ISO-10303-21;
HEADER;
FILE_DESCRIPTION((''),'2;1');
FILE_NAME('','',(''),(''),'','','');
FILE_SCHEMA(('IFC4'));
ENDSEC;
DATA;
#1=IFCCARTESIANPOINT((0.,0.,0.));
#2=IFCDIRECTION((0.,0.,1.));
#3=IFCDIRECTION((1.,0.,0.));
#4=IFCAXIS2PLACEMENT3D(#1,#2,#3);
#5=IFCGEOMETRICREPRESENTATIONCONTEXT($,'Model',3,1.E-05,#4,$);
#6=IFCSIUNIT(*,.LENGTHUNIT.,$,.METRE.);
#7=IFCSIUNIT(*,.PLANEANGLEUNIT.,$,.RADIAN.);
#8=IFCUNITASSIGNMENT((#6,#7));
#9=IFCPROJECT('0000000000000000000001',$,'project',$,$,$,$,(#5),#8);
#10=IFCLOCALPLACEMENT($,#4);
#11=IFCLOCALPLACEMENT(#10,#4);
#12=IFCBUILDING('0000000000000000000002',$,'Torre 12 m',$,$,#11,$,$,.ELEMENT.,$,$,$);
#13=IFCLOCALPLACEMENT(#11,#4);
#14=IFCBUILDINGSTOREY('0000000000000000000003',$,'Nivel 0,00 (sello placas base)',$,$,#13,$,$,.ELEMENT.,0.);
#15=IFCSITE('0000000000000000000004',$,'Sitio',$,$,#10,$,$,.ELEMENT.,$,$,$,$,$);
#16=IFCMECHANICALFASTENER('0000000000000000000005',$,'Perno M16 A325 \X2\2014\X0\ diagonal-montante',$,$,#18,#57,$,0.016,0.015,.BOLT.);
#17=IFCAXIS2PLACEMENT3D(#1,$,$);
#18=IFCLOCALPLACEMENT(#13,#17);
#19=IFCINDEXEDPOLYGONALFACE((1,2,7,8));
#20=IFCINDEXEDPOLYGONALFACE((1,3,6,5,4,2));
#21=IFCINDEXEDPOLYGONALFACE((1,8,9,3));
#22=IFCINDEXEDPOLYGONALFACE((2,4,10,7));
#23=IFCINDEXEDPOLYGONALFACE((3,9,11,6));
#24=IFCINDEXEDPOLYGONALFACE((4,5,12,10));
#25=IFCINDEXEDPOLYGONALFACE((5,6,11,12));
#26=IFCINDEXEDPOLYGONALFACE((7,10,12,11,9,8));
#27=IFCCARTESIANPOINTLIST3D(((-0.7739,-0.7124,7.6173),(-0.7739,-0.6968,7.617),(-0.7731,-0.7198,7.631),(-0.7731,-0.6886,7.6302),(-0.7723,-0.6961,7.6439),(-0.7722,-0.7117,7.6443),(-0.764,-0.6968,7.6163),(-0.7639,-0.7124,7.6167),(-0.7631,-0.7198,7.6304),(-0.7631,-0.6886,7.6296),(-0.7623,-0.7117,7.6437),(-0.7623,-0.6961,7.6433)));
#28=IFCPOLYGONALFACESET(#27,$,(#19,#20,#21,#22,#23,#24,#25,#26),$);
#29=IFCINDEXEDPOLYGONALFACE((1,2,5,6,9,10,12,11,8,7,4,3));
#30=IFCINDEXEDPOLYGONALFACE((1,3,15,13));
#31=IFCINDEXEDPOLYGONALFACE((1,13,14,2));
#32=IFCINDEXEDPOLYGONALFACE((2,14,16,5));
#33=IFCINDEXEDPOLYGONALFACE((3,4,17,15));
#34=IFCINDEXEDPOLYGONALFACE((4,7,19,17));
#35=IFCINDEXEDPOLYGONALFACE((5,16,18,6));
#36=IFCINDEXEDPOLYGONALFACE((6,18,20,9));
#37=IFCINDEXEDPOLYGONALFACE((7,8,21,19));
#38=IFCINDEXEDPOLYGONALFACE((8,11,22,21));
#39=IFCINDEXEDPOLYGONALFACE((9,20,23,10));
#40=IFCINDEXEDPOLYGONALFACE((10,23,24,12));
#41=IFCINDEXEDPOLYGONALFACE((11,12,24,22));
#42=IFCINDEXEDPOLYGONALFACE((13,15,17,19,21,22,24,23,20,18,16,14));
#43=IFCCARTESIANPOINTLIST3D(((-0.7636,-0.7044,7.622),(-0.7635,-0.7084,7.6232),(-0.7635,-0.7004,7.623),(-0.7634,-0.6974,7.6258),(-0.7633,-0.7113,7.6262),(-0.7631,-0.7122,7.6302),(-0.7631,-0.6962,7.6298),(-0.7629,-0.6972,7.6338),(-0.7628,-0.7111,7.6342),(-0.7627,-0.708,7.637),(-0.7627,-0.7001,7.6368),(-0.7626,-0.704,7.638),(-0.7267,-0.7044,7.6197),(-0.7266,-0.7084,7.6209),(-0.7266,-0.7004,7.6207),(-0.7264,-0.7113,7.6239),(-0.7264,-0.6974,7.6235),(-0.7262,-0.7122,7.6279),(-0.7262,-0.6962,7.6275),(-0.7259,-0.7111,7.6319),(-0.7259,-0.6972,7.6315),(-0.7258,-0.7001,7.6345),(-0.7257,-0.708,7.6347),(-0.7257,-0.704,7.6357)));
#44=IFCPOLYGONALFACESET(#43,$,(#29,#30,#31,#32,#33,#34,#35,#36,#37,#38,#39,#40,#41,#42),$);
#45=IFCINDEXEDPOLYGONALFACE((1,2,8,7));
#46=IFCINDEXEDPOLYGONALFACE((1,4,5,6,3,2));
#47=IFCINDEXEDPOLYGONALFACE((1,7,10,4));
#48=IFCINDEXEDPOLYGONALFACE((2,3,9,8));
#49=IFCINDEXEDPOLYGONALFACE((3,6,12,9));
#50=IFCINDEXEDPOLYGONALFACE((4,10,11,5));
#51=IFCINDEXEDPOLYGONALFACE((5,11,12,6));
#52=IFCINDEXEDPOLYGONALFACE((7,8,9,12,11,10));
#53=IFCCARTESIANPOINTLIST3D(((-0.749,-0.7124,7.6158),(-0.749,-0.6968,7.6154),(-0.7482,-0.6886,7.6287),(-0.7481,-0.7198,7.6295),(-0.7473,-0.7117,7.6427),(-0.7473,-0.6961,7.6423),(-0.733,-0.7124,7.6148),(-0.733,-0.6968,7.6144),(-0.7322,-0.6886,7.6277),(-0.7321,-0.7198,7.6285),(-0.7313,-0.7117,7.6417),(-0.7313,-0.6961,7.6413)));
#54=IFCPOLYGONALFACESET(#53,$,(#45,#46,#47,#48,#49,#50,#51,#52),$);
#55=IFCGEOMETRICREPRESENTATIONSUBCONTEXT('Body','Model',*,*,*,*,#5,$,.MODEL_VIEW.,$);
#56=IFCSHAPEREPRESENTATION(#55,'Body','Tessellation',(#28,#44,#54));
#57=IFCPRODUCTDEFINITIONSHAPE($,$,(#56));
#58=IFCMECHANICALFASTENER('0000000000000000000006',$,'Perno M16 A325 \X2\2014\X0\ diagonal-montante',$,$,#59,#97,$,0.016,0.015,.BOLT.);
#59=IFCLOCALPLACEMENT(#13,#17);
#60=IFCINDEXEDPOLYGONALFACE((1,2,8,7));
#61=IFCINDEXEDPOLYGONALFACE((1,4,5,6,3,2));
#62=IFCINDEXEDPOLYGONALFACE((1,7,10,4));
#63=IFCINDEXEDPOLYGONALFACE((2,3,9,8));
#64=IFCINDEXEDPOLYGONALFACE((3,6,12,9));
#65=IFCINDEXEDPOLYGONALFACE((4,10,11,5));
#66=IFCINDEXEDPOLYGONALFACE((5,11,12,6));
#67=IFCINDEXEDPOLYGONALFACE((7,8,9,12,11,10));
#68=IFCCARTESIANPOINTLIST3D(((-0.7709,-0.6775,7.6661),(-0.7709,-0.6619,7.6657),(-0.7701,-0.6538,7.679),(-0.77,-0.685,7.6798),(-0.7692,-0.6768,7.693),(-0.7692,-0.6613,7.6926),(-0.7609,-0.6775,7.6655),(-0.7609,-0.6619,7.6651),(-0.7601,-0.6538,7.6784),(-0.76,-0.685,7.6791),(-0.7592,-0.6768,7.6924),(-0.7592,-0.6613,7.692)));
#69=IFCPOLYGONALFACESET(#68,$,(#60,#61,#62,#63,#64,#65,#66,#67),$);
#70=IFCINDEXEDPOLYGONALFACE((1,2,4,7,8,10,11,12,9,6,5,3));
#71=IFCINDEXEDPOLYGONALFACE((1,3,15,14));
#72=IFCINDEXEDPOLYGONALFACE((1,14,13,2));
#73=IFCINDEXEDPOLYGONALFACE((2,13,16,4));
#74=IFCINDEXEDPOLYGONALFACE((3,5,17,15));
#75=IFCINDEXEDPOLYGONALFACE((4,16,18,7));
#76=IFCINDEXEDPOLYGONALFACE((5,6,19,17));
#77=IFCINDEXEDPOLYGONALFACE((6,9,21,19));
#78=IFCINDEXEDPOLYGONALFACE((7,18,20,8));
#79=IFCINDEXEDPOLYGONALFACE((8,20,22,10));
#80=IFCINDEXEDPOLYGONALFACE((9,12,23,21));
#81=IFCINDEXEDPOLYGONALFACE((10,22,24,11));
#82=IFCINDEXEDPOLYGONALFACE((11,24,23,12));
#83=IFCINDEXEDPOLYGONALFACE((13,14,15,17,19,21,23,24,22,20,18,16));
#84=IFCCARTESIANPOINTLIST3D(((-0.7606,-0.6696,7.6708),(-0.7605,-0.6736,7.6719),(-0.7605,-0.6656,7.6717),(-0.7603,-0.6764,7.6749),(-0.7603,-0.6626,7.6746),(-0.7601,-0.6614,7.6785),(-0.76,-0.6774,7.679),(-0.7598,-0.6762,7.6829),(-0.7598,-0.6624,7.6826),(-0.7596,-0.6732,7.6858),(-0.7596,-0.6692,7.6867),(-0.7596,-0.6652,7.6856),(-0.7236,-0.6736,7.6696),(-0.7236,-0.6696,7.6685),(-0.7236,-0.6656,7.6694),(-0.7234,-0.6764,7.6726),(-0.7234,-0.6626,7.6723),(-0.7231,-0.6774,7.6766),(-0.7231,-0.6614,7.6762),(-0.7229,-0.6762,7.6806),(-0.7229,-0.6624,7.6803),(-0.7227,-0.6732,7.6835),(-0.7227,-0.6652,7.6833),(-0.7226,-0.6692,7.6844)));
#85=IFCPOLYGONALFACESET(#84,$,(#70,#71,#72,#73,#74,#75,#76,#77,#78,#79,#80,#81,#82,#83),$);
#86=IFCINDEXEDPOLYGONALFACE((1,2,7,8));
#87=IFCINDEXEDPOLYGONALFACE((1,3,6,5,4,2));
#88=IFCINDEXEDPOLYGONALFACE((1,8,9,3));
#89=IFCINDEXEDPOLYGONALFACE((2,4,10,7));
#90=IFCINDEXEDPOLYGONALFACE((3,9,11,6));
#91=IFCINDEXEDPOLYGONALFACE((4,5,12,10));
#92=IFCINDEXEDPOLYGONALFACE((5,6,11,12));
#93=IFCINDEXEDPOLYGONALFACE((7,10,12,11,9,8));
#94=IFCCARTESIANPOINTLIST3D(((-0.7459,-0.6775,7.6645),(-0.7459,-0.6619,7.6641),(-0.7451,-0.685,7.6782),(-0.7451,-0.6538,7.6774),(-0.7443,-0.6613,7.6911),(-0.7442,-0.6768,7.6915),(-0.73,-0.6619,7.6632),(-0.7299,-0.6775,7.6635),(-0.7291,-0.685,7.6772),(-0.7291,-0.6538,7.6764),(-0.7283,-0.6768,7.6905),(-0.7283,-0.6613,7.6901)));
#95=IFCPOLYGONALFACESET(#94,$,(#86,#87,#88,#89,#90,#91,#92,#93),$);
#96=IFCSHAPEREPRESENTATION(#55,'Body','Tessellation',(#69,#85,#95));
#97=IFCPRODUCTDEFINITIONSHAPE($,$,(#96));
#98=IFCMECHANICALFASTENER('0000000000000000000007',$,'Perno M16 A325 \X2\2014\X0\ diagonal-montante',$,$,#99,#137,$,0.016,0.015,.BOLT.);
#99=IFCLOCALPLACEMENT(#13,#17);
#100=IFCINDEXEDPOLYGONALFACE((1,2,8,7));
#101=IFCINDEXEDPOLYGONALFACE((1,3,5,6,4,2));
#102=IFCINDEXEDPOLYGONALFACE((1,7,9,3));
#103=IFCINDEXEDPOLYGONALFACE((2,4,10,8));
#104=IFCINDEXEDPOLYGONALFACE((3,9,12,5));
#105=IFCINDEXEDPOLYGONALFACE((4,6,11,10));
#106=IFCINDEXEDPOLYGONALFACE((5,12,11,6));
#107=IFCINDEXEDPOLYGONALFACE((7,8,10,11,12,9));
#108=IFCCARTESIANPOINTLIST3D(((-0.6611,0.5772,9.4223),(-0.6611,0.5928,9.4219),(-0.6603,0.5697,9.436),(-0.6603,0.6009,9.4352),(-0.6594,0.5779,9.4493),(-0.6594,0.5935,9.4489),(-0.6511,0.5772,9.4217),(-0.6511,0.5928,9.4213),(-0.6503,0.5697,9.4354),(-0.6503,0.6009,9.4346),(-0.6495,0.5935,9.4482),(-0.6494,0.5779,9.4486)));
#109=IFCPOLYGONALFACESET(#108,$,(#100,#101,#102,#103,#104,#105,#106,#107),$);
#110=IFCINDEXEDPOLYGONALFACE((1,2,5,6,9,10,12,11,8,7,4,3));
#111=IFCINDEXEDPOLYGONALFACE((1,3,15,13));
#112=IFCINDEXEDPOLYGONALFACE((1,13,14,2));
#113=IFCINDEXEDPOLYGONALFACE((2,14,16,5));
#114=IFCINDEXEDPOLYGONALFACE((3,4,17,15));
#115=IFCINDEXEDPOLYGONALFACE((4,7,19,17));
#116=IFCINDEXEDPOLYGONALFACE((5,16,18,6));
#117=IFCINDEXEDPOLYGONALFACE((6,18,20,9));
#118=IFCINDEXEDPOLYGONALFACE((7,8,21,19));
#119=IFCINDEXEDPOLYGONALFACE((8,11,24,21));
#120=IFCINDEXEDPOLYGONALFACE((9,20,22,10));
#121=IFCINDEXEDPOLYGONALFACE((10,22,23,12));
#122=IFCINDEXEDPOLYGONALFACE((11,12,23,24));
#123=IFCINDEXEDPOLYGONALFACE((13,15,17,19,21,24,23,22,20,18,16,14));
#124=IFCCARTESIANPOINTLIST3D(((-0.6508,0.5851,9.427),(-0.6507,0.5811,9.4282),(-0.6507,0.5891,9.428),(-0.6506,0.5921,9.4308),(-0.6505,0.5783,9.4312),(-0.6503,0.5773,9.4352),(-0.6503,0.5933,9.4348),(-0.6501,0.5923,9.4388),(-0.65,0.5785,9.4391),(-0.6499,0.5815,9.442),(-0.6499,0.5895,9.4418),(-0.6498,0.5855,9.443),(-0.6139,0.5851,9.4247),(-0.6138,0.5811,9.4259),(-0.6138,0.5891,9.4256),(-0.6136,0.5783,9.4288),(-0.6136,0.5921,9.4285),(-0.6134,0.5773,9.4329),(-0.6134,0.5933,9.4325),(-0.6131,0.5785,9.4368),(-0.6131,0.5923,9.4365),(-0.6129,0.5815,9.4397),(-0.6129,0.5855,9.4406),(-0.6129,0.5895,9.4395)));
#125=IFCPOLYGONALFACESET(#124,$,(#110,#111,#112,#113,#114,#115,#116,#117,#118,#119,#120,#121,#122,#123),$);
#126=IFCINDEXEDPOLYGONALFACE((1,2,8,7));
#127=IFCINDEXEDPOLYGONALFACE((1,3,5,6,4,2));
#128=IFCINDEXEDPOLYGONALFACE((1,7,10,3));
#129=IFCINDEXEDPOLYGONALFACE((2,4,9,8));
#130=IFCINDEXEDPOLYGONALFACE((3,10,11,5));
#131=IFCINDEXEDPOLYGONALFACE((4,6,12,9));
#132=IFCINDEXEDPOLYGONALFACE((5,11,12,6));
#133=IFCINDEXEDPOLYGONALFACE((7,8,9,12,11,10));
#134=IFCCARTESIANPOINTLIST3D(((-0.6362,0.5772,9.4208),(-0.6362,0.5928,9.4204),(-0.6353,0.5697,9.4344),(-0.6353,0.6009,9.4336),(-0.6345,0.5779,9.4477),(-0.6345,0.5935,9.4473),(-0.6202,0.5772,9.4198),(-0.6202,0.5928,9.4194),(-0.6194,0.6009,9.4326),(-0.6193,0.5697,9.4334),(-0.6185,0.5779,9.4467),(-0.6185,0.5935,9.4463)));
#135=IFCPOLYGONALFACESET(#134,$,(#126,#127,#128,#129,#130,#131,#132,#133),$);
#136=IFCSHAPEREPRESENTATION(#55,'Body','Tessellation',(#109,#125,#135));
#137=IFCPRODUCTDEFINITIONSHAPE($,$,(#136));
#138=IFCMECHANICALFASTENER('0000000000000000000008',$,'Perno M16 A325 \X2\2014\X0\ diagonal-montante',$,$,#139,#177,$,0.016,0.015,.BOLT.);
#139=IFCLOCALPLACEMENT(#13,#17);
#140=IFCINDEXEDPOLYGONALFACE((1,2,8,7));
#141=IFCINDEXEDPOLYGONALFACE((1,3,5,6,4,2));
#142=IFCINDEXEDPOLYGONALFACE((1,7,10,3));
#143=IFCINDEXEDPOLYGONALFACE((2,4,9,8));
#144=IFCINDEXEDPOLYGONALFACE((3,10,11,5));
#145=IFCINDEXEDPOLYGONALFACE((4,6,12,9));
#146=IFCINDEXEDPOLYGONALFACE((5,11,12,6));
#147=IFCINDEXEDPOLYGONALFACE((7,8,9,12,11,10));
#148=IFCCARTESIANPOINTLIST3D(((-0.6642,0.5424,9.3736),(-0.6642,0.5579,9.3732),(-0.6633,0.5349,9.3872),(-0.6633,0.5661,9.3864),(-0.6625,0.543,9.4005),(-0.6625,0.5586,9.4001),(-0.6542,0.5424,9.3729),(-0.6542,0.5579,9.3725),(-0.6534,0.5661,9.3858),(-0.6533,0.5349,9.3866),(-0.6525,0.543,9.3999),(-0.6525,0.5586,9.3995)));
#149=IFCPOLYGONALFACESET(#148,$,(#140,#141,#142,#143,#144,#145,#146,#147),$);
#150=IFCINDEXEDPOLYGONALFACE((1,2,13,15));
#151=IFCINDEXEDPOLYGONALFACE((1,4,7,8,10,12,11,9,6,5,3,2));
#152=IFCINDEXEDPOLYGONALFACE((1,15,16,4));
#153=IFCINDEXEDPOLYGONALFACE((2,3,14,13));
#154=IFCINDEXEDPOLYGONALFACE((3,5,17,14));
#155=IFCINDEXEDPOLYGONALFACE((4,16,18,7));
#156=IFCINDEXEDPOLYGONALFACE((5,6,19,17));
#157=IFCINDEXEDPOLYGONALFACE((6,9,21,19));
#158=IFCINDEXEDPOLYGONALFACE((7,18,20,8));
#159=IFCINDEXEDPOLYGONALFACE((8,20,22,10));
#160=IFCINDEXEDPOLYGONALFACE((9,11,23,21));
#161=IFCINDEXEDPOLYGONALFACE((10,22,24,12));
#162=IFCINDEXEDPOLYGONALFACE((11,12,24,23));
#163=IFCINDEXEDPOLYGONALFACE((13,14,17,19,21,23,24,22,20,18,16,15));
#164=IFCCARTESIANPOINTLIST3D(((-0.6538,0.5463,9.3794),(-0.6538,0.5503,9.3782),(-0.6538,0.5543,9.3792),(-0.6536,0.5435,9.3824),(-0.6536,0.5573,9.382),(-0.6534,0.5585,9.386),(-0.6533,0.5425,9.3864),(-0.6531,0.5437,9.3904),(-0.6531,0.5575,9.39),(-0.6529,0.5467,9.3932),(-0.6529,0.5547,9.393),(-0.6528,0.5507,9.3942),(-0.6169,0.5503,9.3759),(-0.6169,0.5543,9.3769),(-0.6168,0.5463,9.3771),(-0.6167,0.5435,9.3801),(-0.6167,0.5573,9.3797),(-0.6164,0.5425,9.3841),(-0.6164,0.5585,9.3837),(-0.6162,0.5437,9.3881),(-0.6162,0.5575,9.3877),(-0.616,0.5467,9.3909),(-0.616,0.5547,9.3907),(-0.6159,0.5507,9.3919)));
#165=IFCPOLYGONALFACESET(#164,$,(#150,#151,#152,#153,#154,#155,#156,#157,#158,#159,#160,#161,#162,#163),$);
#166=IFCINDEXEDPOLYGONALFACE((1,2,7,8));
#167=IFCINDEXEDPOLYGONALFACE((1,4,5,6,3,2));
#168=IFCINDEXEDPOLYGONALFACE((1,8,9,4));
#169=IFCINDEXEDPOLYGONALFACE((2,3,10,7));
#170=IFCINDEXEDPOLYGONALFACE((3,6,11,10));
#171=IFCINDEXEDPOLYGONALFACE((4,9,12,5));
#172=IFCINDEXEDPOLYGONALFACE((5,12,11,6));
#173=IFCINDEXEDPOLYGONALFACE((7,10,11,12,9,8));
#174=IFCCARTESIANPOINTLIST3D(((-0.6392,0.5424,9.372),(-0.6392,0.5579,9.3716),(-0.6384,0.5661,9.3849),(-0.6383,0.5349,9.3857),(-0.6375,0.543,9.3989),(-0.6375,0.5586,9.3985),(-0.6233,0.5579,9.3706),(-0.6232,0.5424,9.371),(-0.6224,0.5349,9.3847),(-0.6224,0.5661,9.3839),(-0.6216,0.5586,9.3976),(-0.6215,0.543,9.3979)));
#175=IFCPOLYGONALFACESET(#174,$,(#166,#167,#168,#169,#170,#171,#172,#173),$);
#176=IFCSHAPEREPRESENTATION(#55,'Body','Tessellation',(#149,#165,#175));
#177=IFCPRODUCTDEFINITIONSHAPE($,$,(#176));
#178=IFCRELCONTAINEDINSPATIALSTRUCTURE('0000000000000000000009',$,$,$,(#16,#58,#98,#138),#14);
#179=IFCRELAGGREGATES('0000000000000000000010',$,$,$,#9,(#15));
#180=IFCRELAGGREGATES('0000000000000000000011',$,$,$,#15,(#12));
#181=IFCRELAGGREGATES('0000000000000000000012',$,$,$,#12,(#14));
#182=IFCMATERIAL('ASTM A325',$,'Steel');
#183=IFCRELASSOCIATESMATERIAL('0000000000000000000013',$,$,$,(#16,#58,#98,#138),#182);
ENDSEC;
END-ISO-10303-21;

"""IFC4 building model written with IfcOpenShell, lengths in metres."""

from ifc_helpers import new_model, si_unit, frame, origin_with_axes, place, context, subcontext, project, spatial, polyline, outline, extrude, material, element, save


model = new_model("IFC4")

# Units and contexts
model_context = context("Model", 3, precision=1e-05, world=origin_with_axes())
body_context = subcontext(model_context, "Body", "Model", "MODEL_VIEW")
ifc_project = project(units=[si_unit("LENGTHUNIT", "METRE"), si_unit("PLANEANGLEUNIT", "RADIAN")], contexts=[model_context])

# Site, building, storey
site_placement = place(None, origin_with_axes())
site = spatial("IfcSite", under=ifc_project, at=site_placement, Name="Sitio", CompositionType="ELEMENT")
building_placement = place(site_placement, origin_with_axes())
building = spatial("IfcBuilding", under=site, at=building_placement, Name="Torre 12 m", CompositionType="ELEMENT")
storey_placement = place(building_placement, origin_with_axes())
storey = spatial("IfcBuildingStorey", under=building, at=storey_placement, Name="Nivel 0,00 (sello placas base)", CompositionType="ELEMENT", Elevation=0.0)

# Shared definitions
placement = place(storey_placement, origin_with_axes())

# Mechanical fasteners
ifc_material_1 = material(Name="ASTM A325", Category="Steel")
element("IfcMechanicalFastener", 1, at=placement, inside=storey, material=ifc_material_1, Name="Perno M16 A325 — diagonal-montante", NominalDiameter=0.016, NominalLength=0.015, PredefinedType="BOLT", context=body_context, shape_type="SweptSolid", body=[
    extrude(outline(polyline([(0.0135, 0.0078), (0.0, 0.0156), (-0.0135, 0.0078), (-0.0135, -0.0078), (0.0, -0.0156), (0.0135, -0.0078), (0.0135, 0.0078)])), frame((-0.7731, -0.7042, 7.6306), z_axis=(0.998053, 0.0, -0.062378), x_axis=(0.032557, -0.85299, 0.52091)), (0.0, 0.0, 1.0), 0.01),
    extrude(outline(polyline([(0.008, 0.0), (0.0069, 0.004), (0.004, 0.0069), (0.0, 0.008), (-0.004, 0.0069), (-0.0069, 0.004), (-0.008, 0.0), (-0.0069, -0.004), (-0.004, -0.0069), (0.0, -0.008), (0.004, -0.0069), (0.0069, -0.004), (0.008, 0.0)])), frame((-0.7631, -0.7042, 7.63), z_axis=(0.998053, 0.0, -0.062378), x_axis=(0.032557, -0.85299, 0.52091)), (0.0, 0.0, 1.0), 0.037),
    extrude(outline(polyline([(0.0135, 0.0078), (0.0, 0.0156), (-0.0135, 0.0078), (-0.0135, -0.0078), (0.0, -0.0156), (0.0135, -0.0078), (0.0135, 0.0078)])), frame((-0.7481, -0.7042, 7.6291), z_axis=(0.998053, 0.0, -0.062378), x_axis=(0.032557, -0.85299, 0.52091)), (0.0, 0.0, 1.0), 0.016),
])
element("IfcMechanicalFastener", 2, at=placement, inside=storey, material=ifc_material_1, Name="Perno M16 A325 — diagonal-montante", NominalDiameter=0.016, NominalLength=0.015, PredefinedType="BOLT", context=body_context, shape_type="SweptSolid", body=[
    extrude(outline(polyline([(0.0135, 0.0078), (0.0, 0.0156), (-0.0135, 0.0078), (-0.0135, -0.0078), (0.0, -0.0156), (0.0135, -0.0078), (0.0135, 0.0078)])), frame((-0.77, -0.6694, 7.6794), z_axis=(0.998053, 0.0, -0.062378), x_axis=(0.032557, -0.85299, 0.52091)), (0.0, 0.0, 1.0), 0.01),
    extrude(outline(polyline([(0.008, 0.0), (0.0069, 0.004), (0.004, 0.0069), (0.0, 0.008), (-0.004, 0.0069), (-0.0069, 0.004), (-0.008, 0.0), (-0.0069, -0.004), (-0.004, -0.0069), (0.0, -0.008), (0.004, -0.0069), (0.0069, -0.004), (0.008, 0.0)])), frame((-0.7601, -0.6694, 7.6788), z_axis=(0.998053, 0.0, -0.062378), x_axis=(0.032557, -0.85299, 0.52091)), (0.0, 0.0, 1.0), 0.037),
    extrude(outline(polyline([(0.0135, 0.0078), (0.0, 0.0156), (-0.0135, 0.0078), (-0.0135, -0.0078), (0.0, -0.0156), (0.0135, -0.0078), (0.0135, 0.0078)])), frame((-0.7451, -0.6694, 7.6778), z_axis=(0.998053, 0.0, -0.062378), x_axis=(0.032557, -0.85299, 0.52091)), (0.0, 0.0, 1.0), 0.016),
])
element("IfcMechanicalFastener", 3, at=placement, inside=storey, material=ifc_material_1, Name="Perno M16 A325 — diagonal-montante", NominalDiameter=0.016, NominalLength=0.015, PredefinedType="BOLT", context=body_context, shape_type="SweptSolid", body=[
    extrude(outline(polyline([(0.0135, 0.0078), (0.0, 0.0156), (-0.0135, 0.0078), (-0.0135, -0.0078), (0.0, -0.0156), (0.0135, -0.0078), (0.0135, 0.0078)])), frame((-0.6603, 0.5853, 9.4356), z_axis=(0.998053, 0.0, -0.062378), x_axis=(0.032557, -0.85299, 0.52091)), (0.0, 0.0, 1.0), 0.01),
    extrude(outline(polyline([(0.008, 0.0), (0.0069, 0.004), (0.004, 0.0069), (0.0, 0.008), (-0.004, 0.0069), (-0.0069, 0.004), (-0.008, 0.0), (-0.0069, -0.004), (-0.004, -0.0069), (0.0, -0.008), (0.004, -0.0069), (0.0069, -0.004), (0.008, 0.0)])), frame((-0.6503, 0.5853, 9.435), z_axis=(0.998053, 0.0, -0.062378), x_axis=(0.032557, -0.85299, 0.52091)), (0.0, 0.0, 1.0), 0.037),
    extrude(outline(polyline([(0.0135, 0.0078), (0.0, 0.0156), (-0.0135, 0.0078), (-0.0135, -0.0078), (0.0, -0.0156), (0.0135, -0.0078), (0.0135, 0.0078)])), frame((-0.6353, 0.5853, 9.434), z_axis=(0.998053, 0.0, -0.062378), x_axis=(0.032557, -0.85299, 0.52091)), (0.0, 0.0, 1.0), 0.016),
])
element("IfcMechanicalFastener", 4, at=placement, inside=storey, material=ifc_material_1, Name="Perno M16 A325 — diagonal-montante", NominalDiameter=0.016, NominalLength=0.015, PredefinedType="BOLT", context=body_context, shape_type="SweptSolid", body=[
    extrude(outline(polyline([(0.0135, 0.0078), (0.0, 0.0156), (-0.0135, 0.0078), (-0.0135, -0.0078), (0.0, -0.0156), (0.0135, -0.0078), (0.0135, 0.0078)])), frame((-0.6633, 0.5505, 9.3868), z_axis=(0.998053, 0.0, -0.062378), x_axis=(0.032557, -0.85299, 0.52091)), (0.0, 0.0, 1.0), 0.01),
    extrude(outline(polyline([(0.008, 0.0), (0.0069, 0.004), (0.004, 0.0069), (0.0, 0.008), (-0.004, 0.0069), (-0.0069, 0.004), (-0.008, 0.0), (-0.0069, -0.004), (-0.004, -0.0069), (0.0, -0.008), (0.004, -0.0069), (0.0069, -0.004), (0.008, 0.0)])), frame((-0.6533, 0.5505, 9.3862), z_axis=(0.998053, 0.0, -0.062378), x_axis=(0.032557, -0.85299, 0.52091)), (0.0, 0.0, 1.0), 0.037),
    extrude(outline(polyline([(0.0135, 0.0078), (0.0, 0.0156), (-0.0135, 0.0078), (-0.0135, -0.0078), (0.0, -0.0156), (0.0135, -0.0078), (0.0135, 0.0078)])), frame((-0.6384, 0.5505, 9.3853), z_axis=(0.998053, 0.0, -0.062378), x_axis=(0.032557, -0.85299, 0.52091)), (0.0, 0.0, 1.0), 0.016),
])

save(model, "model.ifc")
